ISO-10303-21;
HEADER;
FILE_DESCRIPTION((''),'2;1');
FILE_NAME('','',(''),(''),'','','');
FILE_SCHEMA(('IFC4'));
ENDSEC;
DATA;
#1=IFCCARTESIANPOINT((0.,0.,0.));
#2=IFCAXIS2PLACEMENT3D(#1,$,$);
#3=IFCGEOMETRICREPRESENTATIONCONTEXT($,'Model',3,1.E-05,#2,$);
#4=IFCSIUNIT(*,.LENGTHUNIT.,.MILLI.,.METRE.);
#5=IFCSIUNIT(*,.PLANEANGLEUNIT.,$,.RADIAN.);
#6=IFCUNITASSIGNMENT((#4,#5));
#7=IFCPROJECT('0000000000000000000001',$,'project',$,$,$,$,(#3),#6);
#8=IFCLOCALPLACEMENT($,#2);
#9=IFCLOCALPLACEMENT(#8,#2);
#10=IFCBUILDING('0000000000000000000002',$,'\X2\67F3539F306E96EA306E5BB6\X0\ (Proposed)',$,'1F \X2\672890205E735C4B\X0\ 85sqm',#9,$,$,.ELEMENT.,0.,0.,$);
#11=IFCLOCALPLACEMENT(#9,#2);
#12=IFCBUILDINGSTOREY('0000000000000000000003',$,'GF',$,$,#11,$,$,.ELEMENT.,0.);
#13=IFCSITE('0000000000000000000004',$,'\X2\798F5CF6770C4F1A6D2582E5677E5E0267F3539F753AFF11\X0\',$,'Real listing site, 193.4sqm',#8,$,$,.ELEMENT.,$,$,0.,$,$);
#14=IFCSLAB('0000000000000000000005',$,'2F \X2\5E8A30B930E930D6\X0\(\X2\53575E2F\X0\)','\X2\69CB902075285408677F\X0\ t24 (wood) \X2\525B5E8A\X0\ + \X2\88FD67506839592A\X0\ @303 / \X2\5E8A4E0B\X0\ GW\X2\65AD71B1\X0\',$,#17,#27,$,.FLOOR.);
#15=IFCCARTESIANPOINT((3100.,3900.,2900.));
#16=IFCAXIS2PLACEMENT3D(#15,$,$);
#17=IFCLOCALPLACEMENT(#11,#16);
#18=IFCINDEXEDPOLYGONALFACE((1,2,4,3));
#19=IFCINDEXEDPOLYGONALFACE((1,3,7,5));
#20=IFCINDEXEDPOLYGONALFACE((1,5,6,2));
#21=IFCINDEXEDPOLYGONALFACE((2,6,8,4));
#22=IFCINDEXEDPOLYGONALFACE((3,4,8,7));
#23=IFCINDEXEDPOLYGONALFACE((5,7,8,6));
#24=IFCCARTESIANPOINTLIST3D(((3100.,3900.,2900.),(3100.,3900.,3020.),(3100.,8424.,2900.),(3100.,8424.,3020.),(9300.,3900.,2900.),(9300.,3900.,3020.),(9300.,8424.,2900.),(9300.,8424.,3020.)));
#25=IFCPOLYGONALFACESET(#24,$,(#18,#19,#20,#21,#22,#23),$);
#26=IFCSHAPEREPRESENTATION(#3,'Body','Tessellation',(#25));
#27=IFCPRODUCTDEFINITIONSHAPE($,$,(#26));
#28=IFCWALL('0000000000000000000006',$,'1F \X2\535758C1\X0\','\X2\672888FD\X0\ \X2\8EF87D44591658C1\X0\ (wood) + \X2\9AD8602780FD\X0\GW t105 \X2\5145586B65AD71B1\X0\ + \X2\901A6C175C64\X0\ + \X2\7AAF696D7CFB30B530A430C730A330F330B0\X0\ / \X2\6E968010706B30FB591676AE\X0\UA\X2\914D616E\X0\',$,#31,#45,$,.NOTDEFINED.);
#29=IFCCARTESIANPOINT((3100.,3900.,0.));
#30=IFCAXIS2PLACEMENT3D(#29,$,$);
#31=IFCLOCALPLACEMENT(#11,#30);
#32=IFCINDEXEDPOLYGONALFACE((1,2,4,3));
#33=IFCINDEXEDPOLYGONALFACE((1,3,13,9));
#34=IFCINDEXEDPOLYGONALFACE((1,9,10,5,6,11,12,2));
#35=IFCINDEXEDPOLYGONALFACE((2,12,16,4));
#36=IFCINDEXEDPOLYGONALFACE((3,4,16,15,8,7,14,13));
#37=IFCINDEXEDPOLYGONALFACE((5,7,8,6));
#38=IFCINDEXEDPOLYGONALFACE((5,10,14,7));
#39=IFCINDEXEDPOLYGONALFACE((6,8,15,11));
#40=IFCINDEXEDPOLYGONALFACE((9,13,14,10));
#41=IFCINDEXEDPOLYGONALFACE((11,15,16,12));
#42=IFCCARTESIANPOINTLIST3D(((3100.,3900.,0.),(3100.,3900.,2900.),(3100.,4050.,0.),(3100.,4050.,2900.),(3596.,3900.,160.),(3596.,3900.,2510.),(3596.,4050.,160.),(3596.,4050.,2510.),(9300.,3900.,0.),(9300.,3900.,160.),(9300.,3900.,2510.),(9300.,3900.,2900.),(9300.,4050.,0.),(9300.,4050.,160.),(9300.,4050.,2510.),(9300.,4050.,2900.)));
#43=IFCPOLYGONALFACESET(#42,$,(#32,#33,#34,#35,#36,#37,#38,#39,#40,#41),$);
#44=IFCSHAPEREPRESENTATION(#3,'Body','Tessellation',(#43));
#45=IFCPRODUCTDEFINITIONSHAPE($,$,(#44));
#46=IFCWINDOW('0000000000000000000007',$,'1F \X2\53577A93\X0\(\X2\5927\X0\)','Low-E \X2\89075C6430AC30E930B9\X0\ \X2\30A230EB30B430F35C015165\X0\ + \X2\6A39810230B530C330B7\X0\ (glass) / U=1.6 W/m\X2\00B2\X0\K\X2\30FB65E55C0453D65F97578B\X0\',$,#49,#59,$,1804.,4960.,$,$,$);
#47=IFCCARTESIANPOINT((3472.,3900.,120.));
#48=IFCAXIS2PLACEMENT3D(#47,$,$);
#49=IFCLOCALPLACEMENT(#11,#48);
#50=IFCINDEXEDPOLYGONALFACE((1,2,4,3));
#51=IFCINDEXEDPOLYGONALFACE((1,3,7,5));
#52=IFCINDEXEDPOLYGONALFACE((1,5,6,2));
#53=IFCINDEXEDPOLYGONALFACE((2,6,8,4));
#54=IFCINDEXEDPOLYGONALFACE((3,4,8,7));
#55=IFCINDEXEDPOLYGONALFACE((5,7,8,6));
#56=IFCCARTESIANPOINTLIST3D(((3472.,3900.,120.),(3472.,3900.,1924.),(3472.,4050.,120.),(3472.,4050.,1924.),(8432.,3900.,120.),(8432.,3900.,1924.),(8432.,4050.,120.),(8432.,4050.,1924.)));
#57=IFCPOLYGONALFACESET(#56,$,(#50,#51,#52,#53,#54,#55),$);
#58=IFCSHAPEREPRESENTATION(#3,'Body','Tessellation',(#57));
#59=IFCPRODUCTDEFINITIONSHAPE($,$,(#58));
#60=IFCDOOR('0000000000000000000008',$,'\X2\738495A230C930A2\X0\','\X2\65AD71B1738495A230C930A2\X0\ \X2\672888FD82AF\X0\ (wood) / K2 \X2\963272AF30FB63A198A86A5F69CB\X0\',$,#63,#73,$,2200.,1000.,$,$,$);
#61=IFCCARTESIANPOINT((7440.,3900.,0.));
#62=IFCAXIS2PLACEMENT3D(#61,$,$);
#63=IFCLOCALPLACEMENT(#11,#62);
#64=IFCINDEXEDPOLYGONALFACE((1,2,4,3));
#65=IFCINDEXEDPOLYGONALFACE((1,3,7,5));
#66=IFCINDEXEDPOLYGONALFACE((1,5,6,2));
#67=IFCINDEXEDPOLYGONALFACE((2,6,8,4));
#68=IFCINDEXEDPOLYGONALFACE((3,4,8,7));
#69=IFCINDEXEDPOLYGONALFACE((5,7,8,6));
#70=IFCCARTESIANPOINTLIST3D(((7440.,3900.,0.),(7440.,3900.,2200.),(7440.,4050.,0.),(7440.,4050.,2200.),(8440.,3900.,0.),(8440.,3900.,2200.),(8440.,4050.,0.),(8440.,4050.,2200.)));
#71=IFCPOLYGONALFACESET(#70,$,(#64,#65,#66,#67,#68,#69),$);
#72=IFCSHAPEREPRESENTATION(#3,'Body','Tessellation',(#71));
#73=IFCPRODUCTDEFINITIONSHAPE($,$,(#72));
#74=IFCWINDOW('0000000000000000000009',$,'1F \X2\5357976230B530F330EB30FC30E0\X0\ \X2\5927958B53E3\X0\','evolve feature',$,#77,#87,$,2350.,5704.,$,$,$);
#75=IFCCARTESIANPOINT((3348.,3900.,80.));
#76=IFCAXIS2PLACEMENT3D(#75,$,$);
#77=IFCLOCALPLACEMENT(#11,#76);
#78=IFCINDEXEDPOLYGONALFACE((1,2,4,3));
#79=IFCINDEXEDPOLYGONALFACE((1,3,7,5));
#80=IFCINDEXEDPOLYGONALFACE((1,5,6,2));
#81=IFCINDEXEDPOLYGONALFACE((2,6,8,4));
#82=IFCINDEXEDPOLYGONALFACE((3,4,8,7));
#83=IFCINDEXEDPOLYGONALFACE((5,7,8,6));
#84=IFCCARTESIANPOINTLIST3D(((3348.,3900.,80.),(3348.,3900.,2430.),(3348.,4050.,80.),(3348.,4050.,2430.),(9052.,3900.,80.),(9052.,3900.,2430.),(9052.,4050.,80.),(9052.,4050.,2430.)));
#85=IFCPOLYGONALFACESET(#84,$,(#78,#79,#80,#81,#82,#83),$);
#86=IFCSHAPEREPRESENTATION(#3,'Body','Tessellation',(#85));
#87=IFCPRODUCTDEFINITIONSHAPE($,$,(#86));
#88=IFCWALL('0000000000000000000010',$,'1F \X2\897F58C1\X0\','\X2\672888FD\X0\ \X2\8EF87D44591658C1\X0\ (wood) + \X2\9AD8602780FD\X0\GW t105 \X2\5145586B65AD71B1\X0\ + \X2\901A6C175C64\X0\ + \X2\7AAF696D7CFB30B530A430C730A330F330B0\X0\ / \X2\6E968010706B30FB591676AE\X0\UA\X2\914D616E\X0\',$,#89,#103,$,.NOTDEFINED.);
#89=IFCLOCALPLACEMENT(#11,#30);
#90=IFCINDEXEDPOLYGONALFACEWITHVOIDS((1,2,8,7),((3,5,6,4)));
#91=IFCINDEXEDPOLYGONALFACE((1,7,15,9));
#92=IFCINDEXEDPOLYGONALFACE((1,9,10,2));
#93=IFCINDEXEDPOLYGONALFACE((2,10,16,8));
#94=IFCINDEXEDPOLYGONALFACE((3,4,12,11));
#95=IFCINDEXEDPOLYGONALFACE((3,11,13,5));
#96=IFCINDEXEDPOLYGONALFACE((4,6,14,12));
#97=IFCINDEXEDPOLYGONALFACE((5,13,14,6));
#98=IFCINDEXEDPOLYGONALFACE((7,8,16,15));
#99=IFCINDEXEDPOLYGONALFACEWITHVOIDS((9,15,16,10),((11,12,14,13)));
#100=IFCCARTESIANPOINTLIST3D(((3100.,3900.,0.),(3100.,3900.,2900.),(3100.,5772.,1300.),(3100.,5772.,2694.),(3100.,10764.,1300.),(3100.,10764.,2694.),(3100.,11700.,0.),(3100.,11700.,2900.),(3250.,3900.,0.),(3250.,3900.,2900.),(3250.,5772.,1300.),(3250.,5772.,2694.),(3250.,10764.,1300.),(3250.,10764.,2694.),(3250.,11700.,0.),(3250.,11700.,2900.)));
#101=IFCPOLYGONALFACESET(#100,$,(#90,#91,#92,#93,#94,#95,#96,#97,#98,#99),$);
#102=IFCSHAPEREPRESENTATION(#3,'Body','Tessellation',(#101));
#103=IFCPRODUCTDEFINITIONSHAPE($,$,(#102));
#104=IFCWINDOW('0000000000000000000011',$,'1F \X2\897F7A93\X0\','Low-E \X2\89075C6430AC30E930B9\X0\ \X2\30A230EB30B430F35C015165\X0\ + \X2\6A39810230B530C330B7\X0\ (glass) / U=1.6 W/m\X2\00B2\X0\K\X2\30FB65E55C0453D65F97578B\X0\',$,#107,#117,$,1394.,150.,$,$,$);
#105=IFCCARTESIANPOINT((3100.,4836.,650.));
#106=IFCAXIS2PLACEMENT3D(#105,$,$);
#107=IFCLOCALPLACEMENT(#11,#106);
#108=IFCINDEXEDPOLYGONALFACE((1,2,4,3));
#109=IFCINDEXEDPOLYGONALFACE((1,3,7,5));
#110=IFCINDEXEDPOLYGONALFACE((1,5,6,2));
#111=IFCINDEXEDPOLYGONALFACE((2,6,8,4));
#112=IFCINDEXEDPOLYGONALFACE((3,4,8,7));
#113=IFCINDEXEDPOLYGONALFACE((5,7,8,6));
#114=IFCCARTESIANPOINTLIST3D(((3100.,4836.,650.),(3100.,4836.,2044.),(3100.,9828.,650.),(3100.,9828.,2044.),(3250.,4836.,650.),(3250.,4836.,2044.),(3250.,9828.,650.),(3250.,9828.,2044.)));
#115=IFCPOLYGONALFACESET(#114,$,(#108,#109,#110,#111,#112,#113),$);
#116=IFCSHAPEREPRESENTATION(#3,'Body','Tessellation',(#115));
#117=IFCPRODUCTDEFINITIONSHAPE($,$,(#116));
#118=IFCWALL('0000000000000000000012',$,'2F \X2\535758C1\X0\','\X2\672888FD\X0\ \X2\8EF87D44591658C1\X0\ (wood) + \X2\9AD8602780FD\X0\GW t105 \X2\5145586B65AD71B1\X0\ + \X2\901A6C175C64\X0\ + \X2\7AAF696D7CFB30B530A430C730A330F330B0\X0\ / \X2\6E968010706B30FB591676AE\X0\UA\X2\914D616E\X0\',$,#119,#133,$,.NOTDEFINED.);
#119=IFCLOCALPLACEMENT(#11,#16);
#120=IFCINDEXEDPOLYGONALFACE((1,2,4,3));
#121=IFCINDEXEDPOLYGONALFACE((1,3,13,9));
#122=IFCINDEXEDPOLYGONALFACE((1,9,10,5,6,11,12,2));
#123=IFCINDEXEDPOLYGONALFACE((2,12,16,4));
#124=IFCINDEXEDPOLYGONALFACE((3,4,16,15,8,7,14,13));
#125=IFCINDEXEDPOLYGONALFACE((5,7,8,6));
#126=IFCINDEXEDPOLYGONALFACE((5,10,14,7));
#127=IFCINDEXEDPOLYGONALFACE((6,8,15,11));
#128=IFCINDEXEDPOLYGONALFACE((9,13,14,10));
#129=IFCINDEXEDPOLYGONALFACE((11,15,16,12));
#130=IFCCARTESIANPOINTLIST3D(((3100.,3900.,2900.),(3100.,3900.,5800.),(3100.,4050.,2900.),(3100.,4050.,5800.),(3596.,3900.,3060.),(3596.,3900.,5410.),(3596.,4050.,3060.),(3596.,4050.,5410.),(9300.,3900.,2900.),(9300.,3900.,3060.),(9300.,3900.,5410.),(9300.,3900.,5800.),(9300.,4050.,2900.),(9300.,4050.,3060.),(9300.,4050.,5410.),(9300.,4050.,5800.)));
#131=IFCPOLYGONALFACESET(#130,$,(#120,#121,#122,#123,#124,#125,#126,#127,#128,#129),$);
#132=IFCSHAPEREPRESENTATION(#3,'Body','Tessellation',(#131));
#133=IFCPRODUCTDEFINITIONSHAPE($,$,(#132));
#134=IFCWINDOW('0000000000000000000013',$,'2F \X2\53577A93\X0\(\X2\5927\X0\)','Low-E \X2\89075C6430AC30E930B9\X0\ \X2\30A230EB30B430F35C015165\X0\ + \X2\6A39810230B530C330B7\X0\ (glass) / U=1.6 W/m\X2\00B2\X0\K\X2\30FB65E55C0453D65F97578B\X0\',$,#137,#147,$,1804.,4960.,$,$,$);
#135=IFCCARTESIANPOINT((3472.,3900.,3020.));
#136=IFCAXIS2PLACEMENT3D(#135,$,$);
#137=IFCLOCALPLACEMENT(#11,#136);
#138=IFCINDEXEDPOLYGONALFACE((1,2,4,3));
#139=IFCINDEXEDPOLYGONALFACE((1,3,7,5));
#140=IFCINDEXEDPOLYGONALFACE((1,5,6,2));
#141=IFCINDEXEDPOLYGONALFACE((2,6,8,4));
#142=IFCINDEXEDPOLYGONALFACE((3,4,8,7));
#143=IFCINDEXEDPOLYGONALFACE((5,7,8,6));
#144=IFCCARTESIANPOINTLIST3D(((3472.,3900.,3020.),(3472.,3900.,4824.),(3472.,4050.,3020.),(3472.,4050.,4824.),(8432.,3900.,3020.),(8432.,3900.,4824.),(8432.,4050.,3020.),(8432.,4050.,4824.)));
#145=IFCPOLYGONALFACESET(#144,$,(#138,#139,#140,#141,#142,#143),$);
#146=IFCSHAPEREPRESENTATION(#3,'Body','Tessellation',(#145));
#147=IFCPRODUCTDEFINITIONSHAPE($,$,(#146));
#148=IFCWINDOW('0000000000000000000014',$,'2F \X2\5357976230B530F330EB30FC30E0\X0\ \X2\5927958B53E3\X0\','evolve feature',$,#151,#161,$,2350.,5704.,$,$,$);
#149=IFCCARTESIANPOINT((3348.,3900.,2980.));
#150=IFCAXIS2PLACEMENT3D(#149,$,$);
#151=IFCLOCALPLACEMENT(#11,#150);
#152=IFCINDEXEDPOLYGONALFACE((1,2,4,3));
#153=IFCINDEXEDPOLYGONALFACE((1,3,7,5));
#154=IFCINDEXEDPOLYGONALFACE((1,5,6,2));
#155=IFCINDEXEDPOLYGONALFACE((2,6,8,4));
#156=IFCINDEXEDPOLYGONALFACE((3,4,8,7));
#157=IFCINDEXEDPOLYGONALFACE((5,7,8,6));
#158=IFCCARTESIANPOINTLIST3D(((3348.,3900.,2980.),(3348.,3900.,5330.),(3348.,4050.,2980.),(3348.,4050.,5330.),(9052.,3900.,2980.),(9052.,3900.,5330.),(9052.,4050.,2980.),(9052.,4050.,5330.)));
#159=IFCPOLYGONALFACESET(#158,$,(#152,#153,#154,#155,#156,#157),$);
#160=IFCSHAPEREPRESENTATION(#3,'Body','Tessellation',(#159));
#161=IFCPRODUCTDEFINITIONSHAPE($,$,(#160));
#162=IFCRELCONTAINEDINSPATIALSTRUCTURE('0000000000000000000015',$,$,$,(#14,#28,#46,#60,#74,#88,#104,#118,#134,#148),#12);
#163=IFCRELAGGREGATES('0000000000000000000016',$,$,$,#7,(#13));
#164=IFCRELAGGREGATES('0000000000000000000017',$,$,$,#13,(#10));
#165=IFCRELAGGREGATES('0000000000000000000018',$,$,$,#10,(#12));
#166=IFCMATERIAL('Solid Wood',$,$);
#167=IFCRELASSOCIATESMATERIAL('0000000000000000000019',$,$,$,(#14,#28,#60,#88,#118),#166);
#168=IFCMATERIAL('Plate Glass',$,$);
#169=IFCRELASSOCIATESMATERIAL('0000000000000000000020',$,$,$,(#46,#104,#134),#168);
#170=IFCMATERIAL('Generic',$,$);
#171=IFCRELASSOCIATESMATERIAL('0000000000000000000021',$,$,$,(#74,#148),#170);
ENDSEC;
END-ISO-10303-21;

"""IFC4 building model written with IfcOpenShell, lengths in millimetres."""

from ifc_helpers import new_model, si_unit, frame, frame_2d, origin, place, context, project, spatial, rectangle, extrude, material, element, fill, save


model = new_model("IFC4")

# Units and contexts
model_context = context("Model", 3, precision=1e-05, world=origin())
ifc_project = project(units=[si_unit("LENGTHUNIT", "METRE", prefix="MILLI"), si_unit("PLANEANGLEUNIT", "RADIAN")], contexts=[model_context])

# Site, building, storey
site_placement = place(None, origin())
site = spatial("IfcSite", under=ifc_project, at=site_placement, Name="福島県会津若松市柳原町１", ObjectType="Real listing site, 193.4sqm", CompositionType="ELEMENT", RefElevation=0.0)
building_placement = place(site_placement, origin())
building = spatial("IfcBuilding", under=site, at=building_placement, Name="柳原の雪の家 (Proposed)", ObjectType="1F 木造平屋 85sqm", CompositionType="ELEMENT", ElevationOfRefHeight=0.0, ElevationOfTerrain=0.0)
storey_placement = place(building_placement, origin())
storey = spatial("IfcBuildingStorey", under=building, at=storey_placement, Name="GF", CompositionType="ELEMENT", Elevation=0.0)

# Slab
ifc_material_1 = material(Name="Solid Wood")
slab_1_placement = place(storey_placement, frame((3100.0, 3900.0, 2900.0)))
element("IfcSlab", 1, at=slab_1_placement, inside=storey, material=ifc_material_1, Name="2F 床スラブ(南帯)", Description="構造用合板 t24 (wood) 剛床 + 製材根太 @303 / 床下 GW断熱", PredefinedType="FLOOR", context=model_context, shape_type="SweptSolid", body=[
    extrude(rectangle(XDim=6200.0, YDim=4524.0, at=frame_2d((3100.0, 2262.0))), frame((3100.0, 3900.0, 2900.0)), (0.0, 0.0, 1.0), 120.0),
])
ifc_material_2 = material(Name="Generic")

# Wall, openings, windows, door
wall_1_placement = place(storey_placement, frame((3100.0, 3900.0, 0.0)))
wall_1 = element("IfcWall", 2, at=wall_1_placement, inside=storey, material=ifc_material_1, Name="1F 南壁", Description="木製 軸組外壁 (wood) + 高性能GW t105 充填断熱 + 通気層 + 窯業系サイディング / 準耐火・外皮UA配慮", PredefinedType="NOTDEFINED", context=model_context, shape_type="SweptSolid", body=[
    extrude(rectangle(XDim=6200.0, YDim=150.0, at=frame_2d((3100.0, 75.0))), frame((3100.0, 3900.0, 0.0)), (0.0, 0.0, 1.0), 2900.0),
])
opening_1_placement = place(storey_placement, frame((3472.0, 3900.0, 120.0)))
opening_1 = element("IfcOpeningElement", 3, at=opening_1_placement, cuts=wall_1, PredefinedType="NOTDEFINED", context=model_context, shape_type="SweptSolid", body=[
    extrude(rectangle(XDim=4960.0, YDim=150.0, at=frame_2d((2480.0, 75.0))), frame((3472.0, 3900.0, 120.0)), (0.0, 0.0, 1.0), 1804.0),
])
opening_2_placement = place(storey_placement, frame((7440.0, 3900.0, 0.0)))
opening_2 = element("IfcOpeningElement", 4, at=opening_2_placement, cuts=wall_1, PredefinedType="NOTDEFINED", context=model_context, shape_type="SweptSolid", body=[
    extrude(rectangle(XDim=1000.0, YDim=150.0, at=frame_2d((500.0, 75.0))), frame((7440.0, 3900.0, 0.0)), (0.0, 0.0, 1.0), 2200.0),
])
opening_3_placement = place(storey_placement, frame((3348.0, 3900.0, 80.0)))
opening_3 = element("IfcOpeningElement", 5, at=opening_3_placement, cuts=wall_1, PredefinedType="NOTDEFINED", context=model_context, shape_type="SweptSolid", body=[
    extrude(rectangle(XDim=5704.0, YDim=150.0, at=frame_2d((2852.0, 75.0))), frame((3348.0, 3900.0, 80.0)), (0.0, 0.0, 1.0), 2350.0),
])
ifc_material_3 = material(Name="Plate Glass")
window_1_placement = place(storey_placement, frame((3472.0, 3900.0, 120.0)))
window_1 = element("IfcWindow", 6, at=window_1_placement, inside=storey, material=ifc_material_3, Name="1F 南窓(大)", Description="Low-E 複層ガラス アルゴン封入 + 樹脂サッシ (glass) / U=1.6 W/m²K・日射取得型", OverallHeight=1804.0, OverallWidth=4960.0, context=model_context, shape_type="SweptSolid", body=[
    extrude(rectangle(XDim=4960.0, YDim=150.0, at=frame_2d((2480.0, 75.0))), frame((3472.0, 3900.0, 120.0)), (0.0, 0.0, 1.0), 1804.0),
])
fill(opening_1, window_1)
door_placement = place(storey_placement, frame((7440.0, 3900.0, 0.0)))
door = element("IfcDoor", 7, at=door_placement, inside=storey, material=ifc_material_1, Name="玄関ドア", Description="断熱玄関ドア 木製芯 (wood) / K2 防犯・採風機構", OverallHeight=2200.0, OverallWidth=1000.0, context=model_context, shape_type="SweptSolid", body=[
    extrude(rectangle(XDim=1000.0, YDim=150.0, at=frame_2d((500.0, 75.0))), frame((7440.0, 3900.0, 0.0)), (0.0, 0.0, 1.0), 2200.0),
])
fill(opening_2, door)
window_2_placement = place(storey_placement, frame((3348.0, 3900.0, 80.0)))
window_2 = element("IfcWindow", 8, at=window_2_placement, inside=storey, material=ifc_material_2, Name="1F 南面サンルーム 大開口", Description="evolve feature", OverallHeight=2350.0, OverallWidth=5704.0, context=model_context, shape_type="SweptSolid", body=[
    extrude(rectangle(XDim=5704.0, YDim=150.0, at=frame_2d((2852.0, 75.0))), frame((3348.0, 3900.0, 80.0)), (0.0, 0.0, 1.0), 2350.0),
])
fill(opening_3, window_2)

# Wall, opening, window
wall_2_placement = place(storey_placement, frame((3100.0, 3900.0, 0.0)))
wall_2 = element("IfcWall", 9, at=wall_2_placement, inside=storey, material=ifc_material_1, Name="1F 西壁", Description="木製 軸組外壁 (wood) + 高性能GW t105 充填断熱 + 通気層 + 窯業系サイディング / 準耐火・外皮UA配慮", PredefinedType="NOTDEFINED", context=model_context, shape_type="SweptSolid", body=[
    extrude(rectangle(XDim=150.0, YDim=7800.0, at=frame_2d((75.0, 3900.0))), frame((3100.0, 3900.0, 0.0)), (0.0, 0.0, 1.0), 2900.0),
])
opening_4_placement = place(storey_placement, frame((3100.0, 4836.0, 650.0)))
opening_4 = element("IfcOpeningElement", 10, at=opening_4_placement, cuts=wall_2, PredefinedType="NOTDEFINED", context=model_context, shape_type="SweptSolid", body=[
    extrude(rectangle(XDim=150.0, YDim=4992.0, at=frame_2d((75.0, 2496.0))), frame((3100.0, 4836.0, 650.0)), (0.0, 0.0, 1.0), 1394.0),
])
window_3_placement = place(storey_placement, frame((3100.0, 4836.0, 650.0)))
window_3 = element("IfcWindow", 11, at=window_3_placement, inside=storey, material=ifc_material_3, Name="1F 西窓", Description="Low-E 複層ガラス アルゴン封入 + 樹脂サッシ (glass) / U=1.6 W/m²K・日射取得型", OverallHeight=1394.0, OverallWidth=150.0, context=model_context, shape_type="SweptSolid", body=[
    extrude(rectangle(XDim=150.0, YDim=4992.0, at=frame_2d((75.0, 2496.0))), frame((3100.0, 4836.0, 650.0)), (0.0, 0.0, 1.0), 1394.0),
])
fill(opening_4, window_3)

# Wall, openings, windows
wall_3_placement = place(storey_placement, frame((3100.0, 3900.0, 2900.0)))
wall_3 = element("IfcWall", 12, at=wall_3_placement, inside=storey, material=ifc_material_1, Name="2F 南壁", Description="木製 軸組外壁 (wood) + 高性能GW t105 充填断熱 + 通気層 + 窯業系サイディング / 準耐火・外皮UA配慮", PredefinedType="NOTDEFINED", context=model_context, shape_type="SweptSolid", body=[
    extrude(rectangle(XDim=6200.0, YDim=150.0, at=frame_2d((3100.0, 75.0))), frame((3100.0, 3900.0, 2900.0)), (0.0, 0.0, 1.0), 2900.0),
])
opening_5_placement = place(storey_placement, frame((3472.0, 3900.0, 3020.0)))
opening_5 = element("IfcOpeningElement", 13, at=opening_5_placement, cuts=wall_3, PredefinedType="NOTDEFINED", context=model_context, shape_type="SweptSolid", body=[
    extrude(rectangle(XDim=4960.0, YDim=150.0, at=frame_2d((2480.0, 75.0))), frame((3472.0, 3900.0, 3020.0)), (0.0, 0.0, 1.0), 1804.0),
])
opening_6_placement = place(storey_placement, frame((3348.0, 3900.0, 2980.0)))
opening_6 = element("IfcOpeningElement", 14, at=opening_6_placement, cuts=wall_3, PredefinedType="NOTDEFINED", context=model_context, shape_type="SweptSolid", body=[
    extrude(rectangle(XDim=5704.0, YDim=150.0, at=frame_2d((2852.0, 75.0))), frame((3348.0, 3900.0, 2980.0)), (0.0, 0.0, 1.0), 2350.0),
])
window_4_placement = place(storey_placement, frame((3472.0, 3900.0, 3020.0)))
window_4 = element("IfcWindow", 15, at=window_4_placement, inside=storey, material=ifc_material_3, Name="2F 南窓(大)", Description="Low-E 複層ガラス アルゴン封入 + 樹脂サッシ (glass) / U=1.6 W/m²K・日射取得型", OverallHeight=1804.0, OverallWidth=4960.0, context=model_context, shape_type="SweptSolid", body=[
    extrude(rectangle(XDim=4960.0, YDim=150.0, at=frame_2d((2480.0, 75.0))), frame((3472.0, 3900.0, 3020.0)), (0.0, 0.0, 1.0), 1804.0),
])
fill(opening_5, window_4)
window_5_placement = place(storey_placement, frame((3348.0, 3900.0, 2980.0)))
window_5 = element("IfcWindow", 16, at=window_5_placement, inside=storey, material=ifc_material_2, Name="2F 南面サンルーム 大開口", Description="evolve feature", OverallHeight=2350.0, OverallWidth=5704.0, context=model_context, shape_type="SweptSolid", body=[
    extrude(rectangle(XDim=5704.0, YDim=150.0, at=frame_2d((2852.0, 75.0))), frame((3348.0, 3900.0, 2980.0)), (0.0, 0.0, 1.0), 2350.0),
])
fill(opening_6, window_5)

save(model, "model.ifc")
